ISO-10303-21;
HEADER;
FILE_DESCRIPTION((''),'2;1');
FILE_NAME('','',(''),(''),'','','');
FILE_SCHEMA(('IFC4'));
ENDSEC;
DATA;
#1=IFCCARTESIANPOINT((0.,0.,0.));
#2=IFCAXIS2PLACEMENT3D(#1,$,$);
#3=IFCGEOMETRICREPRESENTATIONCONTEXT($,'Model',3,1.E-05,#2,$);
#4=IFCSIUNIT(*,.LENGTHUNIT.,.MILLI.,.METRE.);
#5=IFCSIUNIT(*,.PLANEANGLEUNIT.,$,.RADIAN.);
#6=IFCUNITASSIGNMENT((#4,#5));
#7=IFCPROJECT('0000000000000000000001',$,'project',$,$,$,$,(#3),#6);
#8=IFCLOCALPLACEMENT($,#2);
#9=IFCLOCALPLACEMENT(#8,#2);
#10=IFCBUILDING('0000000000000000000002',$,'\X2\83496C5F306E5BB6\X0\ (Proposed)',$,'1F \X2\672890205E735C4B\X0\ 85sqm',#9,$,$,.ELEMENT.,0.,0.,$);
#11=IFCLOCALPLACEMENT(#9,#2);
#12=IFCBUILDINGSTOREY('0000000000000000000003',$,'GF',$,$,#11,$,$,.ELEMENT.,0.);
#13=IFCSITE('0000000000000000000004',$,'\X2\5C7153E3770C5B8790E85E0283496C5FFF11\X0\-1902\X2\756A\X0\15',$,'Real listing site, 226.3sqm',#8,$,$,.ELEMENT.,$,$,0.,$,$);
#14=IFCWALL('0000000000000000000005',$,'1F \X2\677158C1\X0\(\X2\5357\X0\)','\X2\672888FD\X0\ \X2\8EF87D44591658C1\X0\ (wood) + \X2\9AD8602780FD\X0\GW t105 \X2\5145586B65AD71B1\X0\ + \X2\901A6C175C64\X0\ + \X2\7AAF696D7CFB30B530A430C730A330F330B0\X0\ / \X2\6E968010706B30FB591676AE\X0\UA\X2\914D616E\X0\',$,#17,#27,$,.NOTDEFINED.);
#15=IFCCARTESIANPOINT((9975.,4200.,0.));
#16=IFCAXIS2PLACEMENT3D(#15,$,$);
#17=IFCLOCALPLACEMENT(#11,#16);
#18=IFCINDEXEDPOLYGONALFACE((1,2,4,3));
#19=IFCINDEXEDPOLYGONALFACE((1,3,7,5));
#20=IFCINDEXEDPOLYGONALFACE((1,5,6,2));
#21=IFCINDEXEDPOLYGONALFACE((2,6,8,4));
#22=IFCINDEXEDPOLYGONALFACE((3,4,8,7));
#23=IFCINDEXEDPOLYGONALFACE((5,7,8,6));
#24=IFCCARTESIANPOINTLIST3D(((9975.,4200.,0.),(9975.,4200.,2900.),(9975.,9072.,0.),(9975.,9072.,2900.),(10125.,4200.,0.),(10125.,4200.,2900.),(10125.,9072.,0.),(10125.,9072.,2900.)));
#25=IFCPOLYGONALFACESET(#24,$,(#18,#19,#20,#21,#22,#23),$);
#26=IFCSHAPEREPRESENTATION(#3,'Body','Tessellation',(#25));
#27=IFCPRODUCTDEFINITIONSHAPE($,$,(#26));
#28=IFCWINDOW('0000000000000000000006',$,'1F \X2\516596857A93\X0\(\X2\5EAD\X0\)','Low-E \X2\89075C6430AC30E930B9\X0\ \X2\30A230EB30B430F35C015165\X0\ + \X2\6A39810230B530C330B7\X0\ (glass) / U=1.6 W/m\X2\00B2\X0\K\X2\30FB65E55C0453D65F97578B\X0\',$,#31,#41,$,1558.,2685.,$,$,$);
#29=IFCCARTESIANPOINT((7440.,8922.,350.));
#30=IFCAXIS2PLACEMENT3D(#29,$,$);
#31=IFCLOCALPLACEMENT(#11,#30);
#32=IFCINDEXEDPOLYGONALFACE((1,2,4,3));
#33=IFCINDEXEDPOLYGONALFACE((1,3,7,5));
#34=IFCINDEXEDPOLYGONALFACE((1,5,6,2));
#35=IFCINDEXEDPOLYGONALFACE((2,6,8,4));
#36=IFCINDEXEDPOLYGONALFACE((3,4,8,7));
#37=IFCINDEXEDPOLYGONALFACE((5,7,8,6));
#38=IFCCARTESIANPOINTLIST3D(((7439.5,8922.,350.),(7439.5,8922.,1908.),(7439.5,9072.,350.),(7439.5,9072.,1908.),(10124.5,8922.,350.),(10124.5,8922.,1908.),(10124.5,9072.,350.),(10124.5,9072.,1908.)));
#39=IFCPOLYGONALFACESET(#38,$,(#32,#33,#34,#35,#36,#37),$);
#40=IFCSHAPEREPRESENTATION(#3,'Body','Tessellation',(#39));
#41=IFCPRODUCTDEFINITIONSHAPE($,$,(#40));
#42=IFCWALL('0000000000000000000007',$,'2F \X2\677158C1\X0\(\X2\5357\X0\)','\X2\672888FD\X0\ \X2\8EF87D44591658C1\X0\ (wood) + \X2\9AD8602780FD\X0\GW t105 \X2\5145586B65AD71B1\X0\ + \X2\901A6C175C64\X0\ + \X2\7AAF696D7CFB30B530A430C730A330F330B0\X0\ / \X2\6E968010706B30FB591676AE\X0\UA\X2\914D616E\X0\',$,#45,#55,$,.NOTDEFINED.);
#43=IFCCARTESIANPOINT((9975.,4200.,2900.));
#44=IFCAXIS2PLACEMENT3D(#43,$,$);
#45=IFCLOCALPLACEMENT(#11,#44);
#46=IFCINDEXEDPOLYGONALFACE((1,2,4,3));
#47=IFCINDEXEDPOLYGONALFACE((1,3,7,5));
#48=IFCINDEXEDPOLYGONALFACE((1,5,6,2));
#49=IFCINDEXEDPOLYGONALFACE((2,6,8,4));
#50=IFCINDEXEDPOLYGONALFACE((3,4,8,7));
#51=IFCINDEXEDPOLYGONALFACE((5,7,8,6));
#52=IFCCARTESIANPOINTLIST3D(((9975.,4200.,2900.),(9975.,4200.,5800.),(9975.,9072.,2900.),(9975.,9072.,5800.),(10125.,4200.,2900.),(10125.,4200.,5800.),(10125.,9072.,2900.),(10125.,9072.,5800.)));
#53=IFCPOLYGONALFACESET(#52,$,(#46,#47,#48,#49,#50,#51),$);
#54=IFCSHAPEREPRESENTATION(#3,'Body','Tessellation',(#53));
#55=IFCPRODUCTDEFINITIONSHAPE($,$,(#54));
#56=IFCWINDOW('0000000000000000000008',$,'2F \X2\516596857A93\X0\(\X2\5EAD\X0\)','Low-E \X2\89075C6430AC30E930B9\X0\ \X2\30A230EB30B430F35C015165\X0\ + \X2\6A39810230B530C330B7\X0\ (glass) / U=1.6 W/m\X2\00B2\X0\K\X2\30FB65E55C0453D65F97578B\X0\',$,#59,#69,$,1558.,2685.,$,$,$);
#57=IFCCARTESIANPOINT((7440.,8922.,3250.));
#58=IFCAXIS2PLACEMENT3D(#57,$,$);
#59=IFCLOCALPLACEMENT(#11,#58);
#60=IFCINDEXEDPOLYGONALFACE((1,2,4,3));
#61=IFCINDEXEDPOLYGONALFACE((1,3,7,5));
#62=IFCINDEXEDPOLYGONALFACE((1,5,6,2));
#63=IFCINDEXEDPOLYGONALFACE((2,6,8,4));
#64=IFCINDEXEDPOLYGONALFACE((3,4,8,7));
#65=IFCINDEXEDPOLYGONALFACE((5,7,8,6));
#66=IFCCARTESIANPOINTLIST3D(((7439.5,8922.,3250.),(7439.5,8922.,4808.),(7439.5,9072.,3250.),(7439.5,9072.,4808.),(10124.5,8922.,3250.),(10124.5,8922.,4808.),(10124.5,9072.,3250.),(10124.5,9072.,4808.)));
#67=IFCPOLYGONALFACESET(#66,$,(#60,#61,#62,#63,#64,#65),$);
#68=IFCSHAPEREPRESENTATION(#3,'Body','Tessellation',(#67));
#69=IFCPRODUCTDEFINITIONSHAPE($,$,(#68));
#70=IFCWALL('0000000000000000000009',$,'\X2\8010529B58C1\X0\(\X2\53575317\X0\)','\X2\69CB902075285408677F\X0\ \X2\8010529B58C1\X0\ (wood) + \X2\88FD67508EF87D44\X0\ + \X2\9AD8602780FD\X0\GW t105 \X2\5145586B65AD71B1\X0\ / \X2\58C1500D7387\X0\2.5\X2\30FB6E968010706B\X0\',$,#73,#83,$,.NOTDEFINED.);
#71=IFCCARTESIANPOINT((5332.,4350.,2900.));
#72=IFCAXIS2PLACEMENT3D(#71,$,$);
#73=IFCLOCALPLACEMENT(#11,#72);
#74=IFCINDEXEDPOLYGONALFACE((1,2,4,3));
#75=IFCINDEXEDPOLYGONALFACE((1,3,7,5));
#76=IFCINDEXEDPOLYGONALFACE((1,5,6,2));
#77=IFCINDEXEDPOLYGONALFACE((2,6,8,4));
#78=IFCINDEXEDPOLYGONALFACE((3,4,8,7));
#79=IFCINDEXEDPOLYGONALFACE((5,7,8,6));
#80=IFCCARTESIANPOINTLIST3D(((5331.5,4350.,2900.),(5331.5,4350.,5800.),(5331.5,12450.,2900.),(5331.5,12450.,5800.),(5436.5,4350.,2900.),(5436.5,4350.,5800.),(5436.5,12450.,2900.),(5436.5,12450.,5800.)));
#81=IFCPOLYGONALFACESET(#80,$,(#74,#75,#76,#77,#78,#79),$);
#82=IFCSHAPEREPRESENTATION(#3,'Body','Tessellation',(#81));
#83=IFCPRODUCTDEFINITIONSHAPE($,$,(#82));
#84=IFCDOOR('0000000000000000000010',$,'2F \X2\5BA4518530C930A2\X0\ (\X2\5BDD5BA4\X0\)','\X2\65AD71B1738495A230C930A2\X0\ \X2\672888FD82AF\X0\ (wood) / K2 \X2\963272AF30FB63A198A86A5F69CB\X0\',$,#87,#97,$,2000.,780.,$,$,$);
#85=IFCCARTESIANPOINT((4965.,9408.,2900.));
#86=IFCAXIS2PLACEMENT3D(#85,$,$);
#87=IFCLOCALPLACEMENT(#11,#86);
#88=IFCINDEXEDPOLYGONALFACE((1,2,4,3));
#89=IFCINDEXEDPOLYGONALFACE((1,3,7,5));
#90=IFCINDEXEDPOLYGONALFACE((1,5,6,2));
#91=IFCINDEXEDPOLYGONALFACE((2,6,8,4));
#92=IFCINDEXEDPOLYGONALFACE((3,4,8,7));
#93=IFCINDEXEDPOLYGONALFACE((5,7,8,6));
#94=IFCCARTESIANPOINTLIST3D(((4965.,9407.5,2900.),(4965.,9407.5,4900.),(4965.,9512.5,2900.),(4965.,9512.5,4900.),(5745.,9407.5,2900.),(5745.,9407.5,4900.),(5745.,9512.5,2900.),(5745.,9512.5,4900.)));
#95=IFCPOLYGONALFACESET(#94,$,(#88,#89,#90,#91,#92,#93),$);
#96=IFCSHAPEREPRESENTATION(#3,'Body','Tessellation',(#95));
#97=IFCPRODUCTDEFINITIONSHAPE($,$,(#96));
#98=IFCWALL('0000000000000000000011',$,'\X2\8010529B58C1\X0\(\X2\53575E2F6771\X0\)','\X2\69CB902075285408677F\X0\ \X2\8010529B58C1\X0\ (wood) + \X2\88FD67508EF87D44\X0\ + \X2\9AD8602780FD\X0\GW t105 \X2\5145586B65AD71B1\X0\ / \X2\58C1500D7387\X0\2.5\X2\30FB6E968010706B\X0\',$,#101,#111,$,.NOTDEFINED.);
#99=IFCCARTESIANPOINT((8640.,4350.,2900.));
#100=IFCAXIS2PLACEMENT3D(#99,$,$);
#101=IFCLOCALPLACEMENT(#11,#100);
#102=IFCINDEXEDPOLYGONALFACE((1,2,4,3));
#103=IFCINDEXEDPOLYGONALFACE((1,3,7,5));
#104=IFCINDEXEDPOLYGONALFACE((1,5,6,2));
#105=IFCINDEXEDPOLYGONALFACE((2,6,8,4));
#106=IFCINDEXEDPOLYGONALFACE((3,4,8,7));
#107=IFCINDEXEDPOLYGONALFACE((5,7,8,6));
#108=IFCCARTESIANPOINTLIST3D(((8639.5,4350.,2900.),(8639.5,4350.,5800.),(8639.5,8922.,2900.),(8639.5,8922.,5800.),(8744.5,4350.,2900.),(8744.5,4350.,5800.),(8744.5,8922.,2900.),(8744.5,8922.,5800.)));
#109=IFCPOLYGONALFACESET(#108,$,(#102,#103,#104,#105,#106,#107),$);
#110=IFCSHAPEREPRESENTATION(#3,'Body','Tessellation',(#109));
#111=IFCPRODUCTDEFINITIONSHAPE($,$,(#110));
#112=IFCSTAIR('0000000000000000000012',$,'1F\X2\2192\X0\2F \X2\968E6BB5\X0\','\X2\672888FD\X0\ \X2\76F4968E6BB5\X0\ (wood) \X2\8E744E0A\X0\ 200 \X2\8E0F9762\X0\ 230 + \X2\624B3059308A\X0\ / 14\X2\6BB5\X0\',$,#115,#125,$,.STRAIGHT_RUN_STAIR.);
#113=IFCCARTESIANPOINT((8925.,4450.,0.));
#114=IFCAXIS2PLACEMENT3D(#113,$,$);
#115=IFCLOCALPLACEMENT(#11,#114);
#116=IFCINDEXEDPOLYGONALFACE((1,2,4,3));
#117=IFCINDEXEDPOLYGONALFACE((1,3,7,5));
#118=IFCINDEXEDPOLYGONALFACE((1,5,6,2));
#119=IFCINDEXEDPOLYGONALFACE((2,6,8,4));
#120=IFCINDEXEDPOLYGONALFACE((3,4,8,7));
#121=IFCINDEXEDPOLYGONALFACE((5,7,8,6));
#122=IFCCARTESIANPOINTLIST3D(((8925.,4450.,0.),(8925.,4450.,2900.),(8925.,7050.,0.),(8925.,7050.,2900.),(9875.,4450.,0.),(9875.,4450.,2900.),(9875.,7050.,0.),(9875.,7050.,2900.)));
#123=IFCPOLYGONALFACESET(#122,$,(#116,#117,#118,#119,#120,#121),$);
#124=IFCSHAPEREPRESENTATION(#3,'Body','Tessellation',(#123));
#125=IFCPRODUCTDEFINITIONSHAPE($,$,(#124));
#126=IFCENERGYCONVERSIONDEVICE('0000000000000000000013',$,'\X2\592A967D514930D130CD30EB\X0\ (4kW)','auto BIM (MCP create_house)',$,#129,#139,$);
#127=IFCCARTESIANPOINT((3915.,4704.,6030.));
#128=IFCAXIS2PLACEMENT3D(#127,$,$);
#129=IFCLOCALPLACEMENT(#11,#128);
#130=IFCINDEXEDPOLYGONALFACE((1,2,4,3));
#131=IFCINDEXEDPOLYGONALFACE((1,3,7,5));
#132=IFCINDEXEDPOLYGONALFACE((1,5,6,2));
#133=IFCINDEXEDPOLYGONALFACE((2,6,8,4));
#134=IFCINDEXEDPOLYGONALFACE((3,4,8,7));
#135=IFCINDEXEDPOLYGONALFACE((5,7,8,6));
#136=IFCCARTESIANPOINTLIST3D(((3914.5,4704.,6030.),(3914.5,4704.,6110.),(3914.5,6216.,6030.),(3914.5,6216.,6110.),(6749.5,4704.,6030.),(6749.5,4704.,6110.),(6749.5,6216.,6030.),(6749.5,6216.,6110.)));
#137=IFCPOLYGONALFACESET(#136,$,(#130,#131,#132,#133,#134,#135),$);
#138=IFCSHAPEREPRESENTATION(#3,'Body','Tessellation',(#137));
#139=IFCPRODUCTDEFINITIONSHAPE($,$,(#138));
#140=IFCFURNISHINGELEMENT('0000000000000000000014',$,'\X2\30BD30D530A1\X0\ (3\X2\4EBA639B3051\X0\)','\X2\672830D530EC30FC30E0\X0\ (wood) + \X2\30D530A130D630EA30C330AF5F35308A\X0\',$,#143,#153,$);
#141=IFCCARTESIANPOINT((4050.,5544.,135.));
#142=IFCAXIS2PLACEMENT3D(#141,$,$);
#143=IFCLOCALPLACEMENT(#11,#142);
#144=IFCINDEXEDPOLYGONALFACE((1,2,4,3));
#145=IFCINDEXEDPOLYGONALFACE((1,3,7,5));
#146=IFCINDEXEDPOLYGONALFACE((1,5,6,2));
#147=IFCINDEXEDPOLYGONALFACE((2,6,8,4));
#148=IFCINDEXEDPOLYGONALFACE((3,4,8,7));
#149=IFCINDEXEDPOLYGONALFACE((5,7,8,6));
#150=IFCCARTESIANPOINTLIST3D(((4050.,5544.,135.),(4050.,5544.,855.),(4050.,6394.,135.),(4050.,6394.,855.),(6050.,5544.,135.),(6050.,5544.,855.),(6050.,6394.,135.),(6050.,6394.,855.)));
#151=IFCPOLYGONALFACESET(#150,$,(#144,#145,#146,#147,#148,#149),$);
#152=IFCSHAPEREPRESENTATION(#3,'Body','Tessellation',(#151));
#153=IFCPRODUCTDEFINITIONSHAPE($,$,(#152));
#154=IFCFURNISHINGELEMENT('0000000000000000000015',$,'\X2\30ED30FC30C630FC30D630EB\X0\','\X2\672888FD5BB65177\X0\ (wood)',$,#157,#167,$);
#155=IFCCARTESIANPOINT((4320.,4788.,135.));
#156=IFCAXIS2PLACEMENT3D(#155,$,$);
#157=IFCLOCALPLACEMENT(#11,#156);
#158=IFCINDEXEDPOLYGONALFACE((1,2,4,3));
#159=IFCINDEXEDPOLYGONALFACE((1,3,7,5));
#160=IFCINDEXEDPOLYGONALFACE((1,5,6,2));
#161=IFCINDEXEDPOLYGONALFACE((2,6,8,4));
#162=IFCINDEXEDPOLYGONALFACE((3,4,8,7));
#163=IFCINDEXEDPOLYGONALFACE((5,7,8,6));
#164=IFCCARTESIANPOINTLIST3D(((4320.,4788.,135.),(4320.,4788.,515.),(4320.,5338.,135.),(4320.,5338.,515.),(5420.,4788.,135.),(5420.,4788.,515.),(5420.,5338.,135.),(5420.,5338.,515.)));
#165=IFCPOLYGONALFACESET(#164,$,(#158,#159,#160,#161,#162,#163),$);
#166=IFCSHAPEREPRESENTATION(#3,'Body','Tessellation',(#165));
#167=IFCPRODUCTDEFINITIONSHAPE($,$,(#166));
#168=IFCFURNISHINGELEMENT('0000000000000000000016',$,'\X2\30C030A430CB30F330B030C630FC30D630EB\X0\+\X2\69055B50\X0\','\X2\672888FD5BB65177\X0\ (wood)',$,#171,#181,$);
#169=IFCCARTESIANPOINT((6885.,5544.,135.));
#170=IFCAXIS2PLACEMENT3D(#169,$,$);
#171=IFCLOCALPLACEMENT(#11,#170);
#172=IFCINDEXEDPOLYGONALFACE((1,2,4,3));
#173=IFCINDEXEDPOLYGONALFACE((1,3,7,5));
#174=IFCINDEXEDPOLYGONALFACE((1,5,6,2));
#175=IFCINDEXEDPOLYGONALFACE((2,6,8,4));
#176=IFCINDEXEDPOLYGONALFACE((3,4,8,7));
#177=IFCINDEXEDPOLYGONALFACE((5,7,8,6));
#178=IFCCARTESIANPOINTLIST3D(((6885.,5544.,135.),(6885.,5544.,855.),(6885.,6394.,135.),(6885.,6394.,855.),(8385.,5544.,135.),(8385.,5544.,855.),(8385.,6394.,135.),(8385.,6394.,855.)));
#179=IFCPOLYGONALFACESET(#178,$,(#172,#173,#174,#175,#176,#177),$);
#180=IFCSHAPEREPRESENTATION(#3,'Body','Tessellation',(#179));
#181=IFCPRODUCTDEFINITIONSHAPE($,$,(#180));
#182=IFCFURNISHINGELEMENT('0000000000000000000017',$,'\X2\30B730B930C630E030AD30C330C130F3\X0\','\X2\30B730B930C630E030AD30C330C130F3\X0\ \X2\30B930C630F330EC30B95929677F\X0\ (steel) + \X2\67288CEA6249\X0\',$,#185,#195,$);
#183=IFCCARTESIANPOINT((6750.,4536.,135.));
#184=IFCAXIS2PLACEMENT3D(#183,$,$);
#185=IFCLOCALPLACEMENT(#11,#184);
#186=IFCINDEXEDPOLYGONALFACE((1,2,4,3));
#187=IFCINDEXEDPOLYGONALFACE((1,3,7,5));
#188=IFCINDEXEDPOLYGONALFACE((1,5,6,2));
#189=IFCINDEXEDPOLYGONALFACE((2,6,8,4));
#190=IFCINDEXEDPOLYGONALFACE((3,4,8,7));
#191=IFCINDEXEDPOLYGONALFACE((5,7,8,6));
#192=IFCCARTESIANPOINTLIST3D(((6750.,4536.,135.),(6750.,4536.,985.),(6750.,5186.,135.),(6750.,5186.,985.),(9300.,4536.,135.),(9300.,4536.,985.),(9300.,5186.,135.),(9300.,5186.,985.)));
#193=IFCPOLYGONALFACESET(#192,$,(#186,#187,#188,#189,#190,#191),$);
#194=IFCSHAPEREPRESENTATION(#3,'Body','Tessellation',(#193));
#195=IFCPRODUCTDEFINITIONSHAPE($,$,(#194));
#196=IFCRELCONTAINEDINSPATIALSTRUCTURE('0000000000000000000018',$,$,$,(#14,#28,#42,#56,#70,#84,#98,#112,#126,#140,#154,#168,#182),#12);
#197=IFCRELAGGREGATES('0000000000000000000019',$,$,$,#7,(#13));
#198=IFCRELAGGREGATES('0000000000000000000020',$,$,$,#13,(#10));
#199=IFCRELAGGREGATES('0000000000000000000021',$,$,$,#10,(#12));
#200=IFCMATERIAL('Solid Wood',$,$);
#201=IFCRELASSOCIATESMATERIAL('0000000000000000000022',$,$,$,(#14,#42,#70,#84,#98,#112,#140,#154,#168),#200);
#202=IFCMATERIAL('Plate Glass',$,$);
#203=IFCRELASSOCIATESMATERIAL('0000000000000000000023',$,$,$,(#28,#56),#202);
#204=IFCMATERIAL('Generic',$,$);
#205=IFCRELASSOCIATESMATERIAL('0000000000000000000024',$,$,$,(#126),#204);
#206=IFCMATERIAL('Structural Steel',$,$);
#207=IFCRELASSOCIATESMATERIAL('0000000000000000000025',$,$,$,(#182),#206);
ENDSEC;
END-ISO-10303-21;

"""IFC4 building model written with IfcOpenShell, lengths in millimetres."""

from ifc_helpers import new_model, si_unit, frame, frame_2d, origin, place, context, project, spatial, rectangle, extrude, material, element, fill, save


model = new_model("IFC4")

# Units and contexts
model_context = context("Model", 3, precision=1e-05, world=origin())
ifc_project = project(units=[si_unit("LENGTHUNIT", "METRE", prefix="MILLI"), si_unit("PLANEANGLEUNIT", "RADIAN")], contexts=[model_context])

# Site, building, storey
site_placement = place(None, origin())
site = spatial("IfcSite", under=ifc_project, at=site_placement, Name="山口県宇部市草江１-1902番15", ObjectType="Real listing site, 226.3sqm", CompositionType="ELEMENT", RefElevation=0.0)
building_placement = place(site_placement, origin())
building = spatial("IfcBuilding", under=site, at=building_placement, Name="草江の家 (Proposed)", ObjectType="1F 木造平屋 85sqm", CompositionType="ELEMENT", ElevationOfRefHeight=0.0, ElevationOfTerrain=0.0)
storey_placement = place(building_placement, origin())
storey = spatial("IfcBuildingStorey", under=building, at=storey_placement, Name="GF", CompositionType="ELEMENT", Elevation=0.0)

# Wall, opening, window
ifc_material_1 = material(Name="Solid Wood")
wall_1_placement = place(storey_placement, frame((9975.0, 4200.0, 0.0)))
wall_1 = element("IfcWall", 1, at=wall_1_placement, inside=storey, material=ifc_material_1, Name="1F 東壁(南)", Description="木製 軸組外壁 (wood) + 高性能GW t105 充填断熱 + 通気層 + 窯業系サイディング / 準耐火・外皮UA配慮", PredefinedType="NOTDEFINED", context=model_context, shape_type="SweptSolid", body=[
    extrude(rectangle(XDim=150.0, YDim=4872.0, at=frame_2d((75.0, 2436.0))), frame((9975.0, 4200.0, 0.0)), (0.0, 0.0, 1.0), 2900.0),
])
opening_1_placement = place(storey_placement, frame((7440.0, 8922.0, 350.0)))
opening_1 = element("IfcOpeningElement", 2, at=opening_1_placement, cuts=wall_1, PredefinedType="NOTDEFINED", context=model_context, shape_type="SweptSolid", body=[
    extrude(rectangle(XDim=2685.0, YDim=150.0, at=frame_2d((1342.0, 75.0))), frame((7440.0, 8922.0, 350.0)), (0.0, 0.0, 1.0), 1558.0),
])
ifc_material_2 = material(Name="Plate Glass")
window_1_placement = place(storey_placement, frame((7440.0, 8922.0, 350.0)))
window_1 = element("IfcWindow", 3, at=window_1_placement, inside=storey, material=ifc_material_2, Name="1F 入隅窓(庭)", Description="Low-E 複層ガラス アルゴン封入 + 樹脂サッシ (glass) / U=1.6 W/m²K・日射取得型", OverallHeight=1558.0, OverallWidth=2685.0, context=model_context, shape_type="SweptSolid", body=[
    extrude(rectangle(XDim=2685.0, YDim=150.0, at=frame_2d((1342.0, 75.0))), frame((7440.0, 8922.0, 350.0)), (0.0, 0.0, 1.0), 1558.0),
])
fill(opening_1, window_1)

# Wall, opening, window
wall_2_placement = place(storey_placement, frame((9975.0, 4200.0, 2900.0)))
wall_2 = element("IfcWall", 4, at=wall_2_placement, inside=storey, material=ifc_material_1, Name="2F 東壁(南)", Description="木製 軸組外壁 (wood) + 高性能GW t105 充填断熱 + 通気層 + 窯業系サイディング / 準耐火・外皮UA配慮", PredefinedType="NOTDEFINED", context=model_context, shape_type="SweptSolid", body=[
    extrude(rectangle(XDim=150.0, YDim=4872.0, at=frame_2d((75.0, 2436.0))), frame((9975.0, 4200.0, 2900.0)), (0.0, 0.0, 1.0), 2900.0),
])
opening_2_placement = place(storey_placement, frame((7440.0, 8922.0, 3250.0)))
opening_2 = element("IfcOpeningElement", 5, at=opening_2_placement, cuts=wall_2, PredefinedType="NOTDEFINED", context=model_context, shape_type="SweptSolid", body=[
    extrude(rectangle(XDim=2685.0, YDim=150.0, at=frame_2d((1342.0, 75.0))), frame((7440.0, 8922.0, 3250.0)), (0.0, 0.0, 1.0), 1558.0),
])
window_2_placement = place(storey_placement, frame((7440.0, 8922.0, 3250.0)))
window_2 = element("IfcWindow", 6, at=window_2_placement, inside=storey, material=ifc_material_2, Name="2F 入隅窓(庭)", Description="Low-E 複層ガラス アルゴン封入 + 樹脂サッシ (glass) / U=1.6 W/m²K・日射取得型", OverallHeight=1558.0, OverallWidth=2685.0, context=model_context, shape_type="SweptSolid", body=[
    extrude(rectangle(XDim=2685.0, YDim=150.0, at=frame_2d((1342.0, 75.0))), frame((7440.0, 8922.0, 3250.0)), (0.0, 0.0, 1.0), 1558.0),
])
fill(opening_2, window_2)

# Wall, opening, door
wall_3_placement = place(storey_placement, frame((5332.0, 4350.0, 2900.0)))
wall_3 = element("IfcWall", 7, at=wall_3_placement, inside=storey, material=ifc_material_1, Name="耐力壁(南北)", Description="構造用合板 耐力壁 (wood) + 製材軸組 + 高性能GW t105 充填断熱 / 壁倍率2.5・準耐火", PredefinedType="NOTDEFINED", context=model_context, shape_type="SweptSolid", body=[
    extrude(rectangle(XDim=105.0, YDim=8100.0, at=frame_2d((52.0, 4050.0))), frame((5332.0, 4350.0, 2900.0)), (0.0, 0.0, 1.0), 2900.0),
])
opening_3_placement = place(storey_placement, frame((4965.0, 9408.0, 2900.0)))
opening_3 = element("IfcOpeningElement", 8, at=opening_3_placement, cuts=wall_3, PredefinedType="NOTDEFINED", context=model_context, shape_type="SweptSolid", body=[
    extrude(rectangle(XDim=780.0, YDim=105.0, at=frame_2d((390.0, 52.0))), frame((4965.0, 9408.0, 2900.0)), (0.0, 0.0, 1.0), 2000.0),
])
door_1_placement = place(storey_placement, frame((4965.0, 9408.0, 2900.0)))
door_1 = element("IfcDoor", 9, at=door_1_placement, inside=storey, material=ifc_material_1, Name="2F 室内ドア (寝室)", Description="断熱玄関ドア 木製芯 (wood) / K2 防犯・採風機構", OverallHeight=2000.0, OverallWidth=780.0, context=model_context, shape_type="SweptSolid", body=[
    extrude(rectangle(XDim=780.0, YDim=105.0, at=frame_2d((390.0, 52.0))), frame((4965.0, 9408.0, 2900.0)), (0.0, 0.0, 1.0), 2000.0),
])
fill(opening_3, door_1)

# Wall
wall_4_placement = place(storey_placement, frame((8640.0, 4350.0, 2900.0)))
element("IfcWall", 10, at=wall_4_placement, inside=storey, material=ifc_material_1, Name="耐力壁(南帯東)", Description="構造用合板 耐力壁 (wood) + 製材軸組 + 高性能GW t105 充填断熱 / 壁倍率2.5・準耐火", PredefinedType="NOTDEFINED", context=model_context, shape_type="SweptSolid", body=[
    extrude(rectangle(XDim=105.0, YDim=4572.0, at=frame_2d((52.0, 2286.0))), frame((8640.0, 4350.0, 2900.0)), (0.0, 0.0, 1.0), 2900.0),
])

# Stair
stair_placement = place(storey_placement, frame((8925.0, 4450.0, 0.0)))
element("IfcStair", 11, at=stair_placement, inside=storey, material=ifc_material_1, Name="1F→2F 階段", Description="木製 直階段 (wood) 蹴上 200 踏面 230 + 手すり / 14段", PredefinedType="STRAIGHT_RUN_STAIR", context=model_context, shape_type="SweptSolid", body=[
    extrude(rectangle(XDim=950.0, YDim=2600.0, at=frame_2d((475.0, 1300.0))), frame((8925.0, 4450.0, 0.0)), (0.0, 0.0, 1.0), 2900.0),
])

# Energy conversion device
ifc_material_3 = material(Name="Generic")
energy_conversion_device_placement = place(storey_placement, frame((3915.0, 4704.0, 6030.0)))
element("IfcEnergyConversionDevice", 12, at=energy_conversion_device_placement, inside=storey, material=ifc_material_3, Name="太陽光パネル (4kW)", Description="auto BIM (MCP create_house)", context=model_context, shape_type="SweptSolid", body=[
    extrude(rectangle(XDim=2835.0, YDim=1512.0, at=frame_2d((1417.0, 756.0))), frame((3915.0, 4704.0, 6030.0)), (0.0, 0.0, 1.0), 80.0),
])

# Furnishing elements
furnishing_1_placement = place(storey_placement, frame((4050.0, 5544.0, 135.0)))
element("IfcFurnishingElement", 13, at=furnishing_1_placement, inside=storey, material=ifc_material_1, Name="ソファ (3人掛け)", Description="木フレーム (wood) + ファブリック張り", context=model_context, shape_type="SweptSolid", body=[
    extrude(rectangle(XDim=2000.0, YDim=850.0, at=frame_2d((1000.0, 425.0))), frame((4050.0, 5544.0, 135.0)), (0.0, 0.0, 1.0), 720.0),
])
furnishing_2_placement = place(storey_placement, frame((4320.0, 4788.0, 135.0)))
element("IfcFurnishingElement", 14, at=furnishing_2_placement, inside=storey, material=ifc_material_1, Name="ローテーブル", Description="木製家具 (wood)", context=model_context, shape_type="SweptSolid", body=[
    extrude(rectangle(XDim=1100.0, YDim=550.0, at=frame_2d((550.0, 275.0))), frame((4320.0, 4788.0, 135.0)), (0.0, 0.0, 1.0), 380.0),
])
furnishing_3_placement = place(storey_placement, frame((6885.0, 5544.0, 135.0)))
element("IfcFurnishingElement", 15, at=furnishing_3_placement, inside=storey, material=ifc_material_1, Name="ダイニングテーブル+椅子", Description="木製家具 (wood)", context=model_context, shape_type="SweptSolid", body=[
    extrude(rectangle(XDim=1500.0, YDim=850.0, at=frame_2d((750.0, 425.0))), frame((6885.0, 5544.0, 135.0)), (0.0, 0.0, 1.0), 720.0),
])
ifc_material_4 = material(Name="Structural Steel")
furnishing_4_placement = place(storey_placement, frame((6750.0, 4536.0, 135.0)))
element("IfcFurnishingElement", 16, at=furnishing_4_placement, inside=storey, material=ifc_material_4, Name="システムキッチン", Description="システムキッチン ステンレス天板 (steel) + 木質扉", context=model_context, shape_type="SweptSolid", body=[
    extrude(rectangle(XDim=2550.0, YDim=650.0, at=frame_2d((1275.0, 325.0))), frame((6750.0, 4536.0, 135.0)), (0.0, 0.0, 1.0), 850.0),
])

save(model, "model.ifc")
